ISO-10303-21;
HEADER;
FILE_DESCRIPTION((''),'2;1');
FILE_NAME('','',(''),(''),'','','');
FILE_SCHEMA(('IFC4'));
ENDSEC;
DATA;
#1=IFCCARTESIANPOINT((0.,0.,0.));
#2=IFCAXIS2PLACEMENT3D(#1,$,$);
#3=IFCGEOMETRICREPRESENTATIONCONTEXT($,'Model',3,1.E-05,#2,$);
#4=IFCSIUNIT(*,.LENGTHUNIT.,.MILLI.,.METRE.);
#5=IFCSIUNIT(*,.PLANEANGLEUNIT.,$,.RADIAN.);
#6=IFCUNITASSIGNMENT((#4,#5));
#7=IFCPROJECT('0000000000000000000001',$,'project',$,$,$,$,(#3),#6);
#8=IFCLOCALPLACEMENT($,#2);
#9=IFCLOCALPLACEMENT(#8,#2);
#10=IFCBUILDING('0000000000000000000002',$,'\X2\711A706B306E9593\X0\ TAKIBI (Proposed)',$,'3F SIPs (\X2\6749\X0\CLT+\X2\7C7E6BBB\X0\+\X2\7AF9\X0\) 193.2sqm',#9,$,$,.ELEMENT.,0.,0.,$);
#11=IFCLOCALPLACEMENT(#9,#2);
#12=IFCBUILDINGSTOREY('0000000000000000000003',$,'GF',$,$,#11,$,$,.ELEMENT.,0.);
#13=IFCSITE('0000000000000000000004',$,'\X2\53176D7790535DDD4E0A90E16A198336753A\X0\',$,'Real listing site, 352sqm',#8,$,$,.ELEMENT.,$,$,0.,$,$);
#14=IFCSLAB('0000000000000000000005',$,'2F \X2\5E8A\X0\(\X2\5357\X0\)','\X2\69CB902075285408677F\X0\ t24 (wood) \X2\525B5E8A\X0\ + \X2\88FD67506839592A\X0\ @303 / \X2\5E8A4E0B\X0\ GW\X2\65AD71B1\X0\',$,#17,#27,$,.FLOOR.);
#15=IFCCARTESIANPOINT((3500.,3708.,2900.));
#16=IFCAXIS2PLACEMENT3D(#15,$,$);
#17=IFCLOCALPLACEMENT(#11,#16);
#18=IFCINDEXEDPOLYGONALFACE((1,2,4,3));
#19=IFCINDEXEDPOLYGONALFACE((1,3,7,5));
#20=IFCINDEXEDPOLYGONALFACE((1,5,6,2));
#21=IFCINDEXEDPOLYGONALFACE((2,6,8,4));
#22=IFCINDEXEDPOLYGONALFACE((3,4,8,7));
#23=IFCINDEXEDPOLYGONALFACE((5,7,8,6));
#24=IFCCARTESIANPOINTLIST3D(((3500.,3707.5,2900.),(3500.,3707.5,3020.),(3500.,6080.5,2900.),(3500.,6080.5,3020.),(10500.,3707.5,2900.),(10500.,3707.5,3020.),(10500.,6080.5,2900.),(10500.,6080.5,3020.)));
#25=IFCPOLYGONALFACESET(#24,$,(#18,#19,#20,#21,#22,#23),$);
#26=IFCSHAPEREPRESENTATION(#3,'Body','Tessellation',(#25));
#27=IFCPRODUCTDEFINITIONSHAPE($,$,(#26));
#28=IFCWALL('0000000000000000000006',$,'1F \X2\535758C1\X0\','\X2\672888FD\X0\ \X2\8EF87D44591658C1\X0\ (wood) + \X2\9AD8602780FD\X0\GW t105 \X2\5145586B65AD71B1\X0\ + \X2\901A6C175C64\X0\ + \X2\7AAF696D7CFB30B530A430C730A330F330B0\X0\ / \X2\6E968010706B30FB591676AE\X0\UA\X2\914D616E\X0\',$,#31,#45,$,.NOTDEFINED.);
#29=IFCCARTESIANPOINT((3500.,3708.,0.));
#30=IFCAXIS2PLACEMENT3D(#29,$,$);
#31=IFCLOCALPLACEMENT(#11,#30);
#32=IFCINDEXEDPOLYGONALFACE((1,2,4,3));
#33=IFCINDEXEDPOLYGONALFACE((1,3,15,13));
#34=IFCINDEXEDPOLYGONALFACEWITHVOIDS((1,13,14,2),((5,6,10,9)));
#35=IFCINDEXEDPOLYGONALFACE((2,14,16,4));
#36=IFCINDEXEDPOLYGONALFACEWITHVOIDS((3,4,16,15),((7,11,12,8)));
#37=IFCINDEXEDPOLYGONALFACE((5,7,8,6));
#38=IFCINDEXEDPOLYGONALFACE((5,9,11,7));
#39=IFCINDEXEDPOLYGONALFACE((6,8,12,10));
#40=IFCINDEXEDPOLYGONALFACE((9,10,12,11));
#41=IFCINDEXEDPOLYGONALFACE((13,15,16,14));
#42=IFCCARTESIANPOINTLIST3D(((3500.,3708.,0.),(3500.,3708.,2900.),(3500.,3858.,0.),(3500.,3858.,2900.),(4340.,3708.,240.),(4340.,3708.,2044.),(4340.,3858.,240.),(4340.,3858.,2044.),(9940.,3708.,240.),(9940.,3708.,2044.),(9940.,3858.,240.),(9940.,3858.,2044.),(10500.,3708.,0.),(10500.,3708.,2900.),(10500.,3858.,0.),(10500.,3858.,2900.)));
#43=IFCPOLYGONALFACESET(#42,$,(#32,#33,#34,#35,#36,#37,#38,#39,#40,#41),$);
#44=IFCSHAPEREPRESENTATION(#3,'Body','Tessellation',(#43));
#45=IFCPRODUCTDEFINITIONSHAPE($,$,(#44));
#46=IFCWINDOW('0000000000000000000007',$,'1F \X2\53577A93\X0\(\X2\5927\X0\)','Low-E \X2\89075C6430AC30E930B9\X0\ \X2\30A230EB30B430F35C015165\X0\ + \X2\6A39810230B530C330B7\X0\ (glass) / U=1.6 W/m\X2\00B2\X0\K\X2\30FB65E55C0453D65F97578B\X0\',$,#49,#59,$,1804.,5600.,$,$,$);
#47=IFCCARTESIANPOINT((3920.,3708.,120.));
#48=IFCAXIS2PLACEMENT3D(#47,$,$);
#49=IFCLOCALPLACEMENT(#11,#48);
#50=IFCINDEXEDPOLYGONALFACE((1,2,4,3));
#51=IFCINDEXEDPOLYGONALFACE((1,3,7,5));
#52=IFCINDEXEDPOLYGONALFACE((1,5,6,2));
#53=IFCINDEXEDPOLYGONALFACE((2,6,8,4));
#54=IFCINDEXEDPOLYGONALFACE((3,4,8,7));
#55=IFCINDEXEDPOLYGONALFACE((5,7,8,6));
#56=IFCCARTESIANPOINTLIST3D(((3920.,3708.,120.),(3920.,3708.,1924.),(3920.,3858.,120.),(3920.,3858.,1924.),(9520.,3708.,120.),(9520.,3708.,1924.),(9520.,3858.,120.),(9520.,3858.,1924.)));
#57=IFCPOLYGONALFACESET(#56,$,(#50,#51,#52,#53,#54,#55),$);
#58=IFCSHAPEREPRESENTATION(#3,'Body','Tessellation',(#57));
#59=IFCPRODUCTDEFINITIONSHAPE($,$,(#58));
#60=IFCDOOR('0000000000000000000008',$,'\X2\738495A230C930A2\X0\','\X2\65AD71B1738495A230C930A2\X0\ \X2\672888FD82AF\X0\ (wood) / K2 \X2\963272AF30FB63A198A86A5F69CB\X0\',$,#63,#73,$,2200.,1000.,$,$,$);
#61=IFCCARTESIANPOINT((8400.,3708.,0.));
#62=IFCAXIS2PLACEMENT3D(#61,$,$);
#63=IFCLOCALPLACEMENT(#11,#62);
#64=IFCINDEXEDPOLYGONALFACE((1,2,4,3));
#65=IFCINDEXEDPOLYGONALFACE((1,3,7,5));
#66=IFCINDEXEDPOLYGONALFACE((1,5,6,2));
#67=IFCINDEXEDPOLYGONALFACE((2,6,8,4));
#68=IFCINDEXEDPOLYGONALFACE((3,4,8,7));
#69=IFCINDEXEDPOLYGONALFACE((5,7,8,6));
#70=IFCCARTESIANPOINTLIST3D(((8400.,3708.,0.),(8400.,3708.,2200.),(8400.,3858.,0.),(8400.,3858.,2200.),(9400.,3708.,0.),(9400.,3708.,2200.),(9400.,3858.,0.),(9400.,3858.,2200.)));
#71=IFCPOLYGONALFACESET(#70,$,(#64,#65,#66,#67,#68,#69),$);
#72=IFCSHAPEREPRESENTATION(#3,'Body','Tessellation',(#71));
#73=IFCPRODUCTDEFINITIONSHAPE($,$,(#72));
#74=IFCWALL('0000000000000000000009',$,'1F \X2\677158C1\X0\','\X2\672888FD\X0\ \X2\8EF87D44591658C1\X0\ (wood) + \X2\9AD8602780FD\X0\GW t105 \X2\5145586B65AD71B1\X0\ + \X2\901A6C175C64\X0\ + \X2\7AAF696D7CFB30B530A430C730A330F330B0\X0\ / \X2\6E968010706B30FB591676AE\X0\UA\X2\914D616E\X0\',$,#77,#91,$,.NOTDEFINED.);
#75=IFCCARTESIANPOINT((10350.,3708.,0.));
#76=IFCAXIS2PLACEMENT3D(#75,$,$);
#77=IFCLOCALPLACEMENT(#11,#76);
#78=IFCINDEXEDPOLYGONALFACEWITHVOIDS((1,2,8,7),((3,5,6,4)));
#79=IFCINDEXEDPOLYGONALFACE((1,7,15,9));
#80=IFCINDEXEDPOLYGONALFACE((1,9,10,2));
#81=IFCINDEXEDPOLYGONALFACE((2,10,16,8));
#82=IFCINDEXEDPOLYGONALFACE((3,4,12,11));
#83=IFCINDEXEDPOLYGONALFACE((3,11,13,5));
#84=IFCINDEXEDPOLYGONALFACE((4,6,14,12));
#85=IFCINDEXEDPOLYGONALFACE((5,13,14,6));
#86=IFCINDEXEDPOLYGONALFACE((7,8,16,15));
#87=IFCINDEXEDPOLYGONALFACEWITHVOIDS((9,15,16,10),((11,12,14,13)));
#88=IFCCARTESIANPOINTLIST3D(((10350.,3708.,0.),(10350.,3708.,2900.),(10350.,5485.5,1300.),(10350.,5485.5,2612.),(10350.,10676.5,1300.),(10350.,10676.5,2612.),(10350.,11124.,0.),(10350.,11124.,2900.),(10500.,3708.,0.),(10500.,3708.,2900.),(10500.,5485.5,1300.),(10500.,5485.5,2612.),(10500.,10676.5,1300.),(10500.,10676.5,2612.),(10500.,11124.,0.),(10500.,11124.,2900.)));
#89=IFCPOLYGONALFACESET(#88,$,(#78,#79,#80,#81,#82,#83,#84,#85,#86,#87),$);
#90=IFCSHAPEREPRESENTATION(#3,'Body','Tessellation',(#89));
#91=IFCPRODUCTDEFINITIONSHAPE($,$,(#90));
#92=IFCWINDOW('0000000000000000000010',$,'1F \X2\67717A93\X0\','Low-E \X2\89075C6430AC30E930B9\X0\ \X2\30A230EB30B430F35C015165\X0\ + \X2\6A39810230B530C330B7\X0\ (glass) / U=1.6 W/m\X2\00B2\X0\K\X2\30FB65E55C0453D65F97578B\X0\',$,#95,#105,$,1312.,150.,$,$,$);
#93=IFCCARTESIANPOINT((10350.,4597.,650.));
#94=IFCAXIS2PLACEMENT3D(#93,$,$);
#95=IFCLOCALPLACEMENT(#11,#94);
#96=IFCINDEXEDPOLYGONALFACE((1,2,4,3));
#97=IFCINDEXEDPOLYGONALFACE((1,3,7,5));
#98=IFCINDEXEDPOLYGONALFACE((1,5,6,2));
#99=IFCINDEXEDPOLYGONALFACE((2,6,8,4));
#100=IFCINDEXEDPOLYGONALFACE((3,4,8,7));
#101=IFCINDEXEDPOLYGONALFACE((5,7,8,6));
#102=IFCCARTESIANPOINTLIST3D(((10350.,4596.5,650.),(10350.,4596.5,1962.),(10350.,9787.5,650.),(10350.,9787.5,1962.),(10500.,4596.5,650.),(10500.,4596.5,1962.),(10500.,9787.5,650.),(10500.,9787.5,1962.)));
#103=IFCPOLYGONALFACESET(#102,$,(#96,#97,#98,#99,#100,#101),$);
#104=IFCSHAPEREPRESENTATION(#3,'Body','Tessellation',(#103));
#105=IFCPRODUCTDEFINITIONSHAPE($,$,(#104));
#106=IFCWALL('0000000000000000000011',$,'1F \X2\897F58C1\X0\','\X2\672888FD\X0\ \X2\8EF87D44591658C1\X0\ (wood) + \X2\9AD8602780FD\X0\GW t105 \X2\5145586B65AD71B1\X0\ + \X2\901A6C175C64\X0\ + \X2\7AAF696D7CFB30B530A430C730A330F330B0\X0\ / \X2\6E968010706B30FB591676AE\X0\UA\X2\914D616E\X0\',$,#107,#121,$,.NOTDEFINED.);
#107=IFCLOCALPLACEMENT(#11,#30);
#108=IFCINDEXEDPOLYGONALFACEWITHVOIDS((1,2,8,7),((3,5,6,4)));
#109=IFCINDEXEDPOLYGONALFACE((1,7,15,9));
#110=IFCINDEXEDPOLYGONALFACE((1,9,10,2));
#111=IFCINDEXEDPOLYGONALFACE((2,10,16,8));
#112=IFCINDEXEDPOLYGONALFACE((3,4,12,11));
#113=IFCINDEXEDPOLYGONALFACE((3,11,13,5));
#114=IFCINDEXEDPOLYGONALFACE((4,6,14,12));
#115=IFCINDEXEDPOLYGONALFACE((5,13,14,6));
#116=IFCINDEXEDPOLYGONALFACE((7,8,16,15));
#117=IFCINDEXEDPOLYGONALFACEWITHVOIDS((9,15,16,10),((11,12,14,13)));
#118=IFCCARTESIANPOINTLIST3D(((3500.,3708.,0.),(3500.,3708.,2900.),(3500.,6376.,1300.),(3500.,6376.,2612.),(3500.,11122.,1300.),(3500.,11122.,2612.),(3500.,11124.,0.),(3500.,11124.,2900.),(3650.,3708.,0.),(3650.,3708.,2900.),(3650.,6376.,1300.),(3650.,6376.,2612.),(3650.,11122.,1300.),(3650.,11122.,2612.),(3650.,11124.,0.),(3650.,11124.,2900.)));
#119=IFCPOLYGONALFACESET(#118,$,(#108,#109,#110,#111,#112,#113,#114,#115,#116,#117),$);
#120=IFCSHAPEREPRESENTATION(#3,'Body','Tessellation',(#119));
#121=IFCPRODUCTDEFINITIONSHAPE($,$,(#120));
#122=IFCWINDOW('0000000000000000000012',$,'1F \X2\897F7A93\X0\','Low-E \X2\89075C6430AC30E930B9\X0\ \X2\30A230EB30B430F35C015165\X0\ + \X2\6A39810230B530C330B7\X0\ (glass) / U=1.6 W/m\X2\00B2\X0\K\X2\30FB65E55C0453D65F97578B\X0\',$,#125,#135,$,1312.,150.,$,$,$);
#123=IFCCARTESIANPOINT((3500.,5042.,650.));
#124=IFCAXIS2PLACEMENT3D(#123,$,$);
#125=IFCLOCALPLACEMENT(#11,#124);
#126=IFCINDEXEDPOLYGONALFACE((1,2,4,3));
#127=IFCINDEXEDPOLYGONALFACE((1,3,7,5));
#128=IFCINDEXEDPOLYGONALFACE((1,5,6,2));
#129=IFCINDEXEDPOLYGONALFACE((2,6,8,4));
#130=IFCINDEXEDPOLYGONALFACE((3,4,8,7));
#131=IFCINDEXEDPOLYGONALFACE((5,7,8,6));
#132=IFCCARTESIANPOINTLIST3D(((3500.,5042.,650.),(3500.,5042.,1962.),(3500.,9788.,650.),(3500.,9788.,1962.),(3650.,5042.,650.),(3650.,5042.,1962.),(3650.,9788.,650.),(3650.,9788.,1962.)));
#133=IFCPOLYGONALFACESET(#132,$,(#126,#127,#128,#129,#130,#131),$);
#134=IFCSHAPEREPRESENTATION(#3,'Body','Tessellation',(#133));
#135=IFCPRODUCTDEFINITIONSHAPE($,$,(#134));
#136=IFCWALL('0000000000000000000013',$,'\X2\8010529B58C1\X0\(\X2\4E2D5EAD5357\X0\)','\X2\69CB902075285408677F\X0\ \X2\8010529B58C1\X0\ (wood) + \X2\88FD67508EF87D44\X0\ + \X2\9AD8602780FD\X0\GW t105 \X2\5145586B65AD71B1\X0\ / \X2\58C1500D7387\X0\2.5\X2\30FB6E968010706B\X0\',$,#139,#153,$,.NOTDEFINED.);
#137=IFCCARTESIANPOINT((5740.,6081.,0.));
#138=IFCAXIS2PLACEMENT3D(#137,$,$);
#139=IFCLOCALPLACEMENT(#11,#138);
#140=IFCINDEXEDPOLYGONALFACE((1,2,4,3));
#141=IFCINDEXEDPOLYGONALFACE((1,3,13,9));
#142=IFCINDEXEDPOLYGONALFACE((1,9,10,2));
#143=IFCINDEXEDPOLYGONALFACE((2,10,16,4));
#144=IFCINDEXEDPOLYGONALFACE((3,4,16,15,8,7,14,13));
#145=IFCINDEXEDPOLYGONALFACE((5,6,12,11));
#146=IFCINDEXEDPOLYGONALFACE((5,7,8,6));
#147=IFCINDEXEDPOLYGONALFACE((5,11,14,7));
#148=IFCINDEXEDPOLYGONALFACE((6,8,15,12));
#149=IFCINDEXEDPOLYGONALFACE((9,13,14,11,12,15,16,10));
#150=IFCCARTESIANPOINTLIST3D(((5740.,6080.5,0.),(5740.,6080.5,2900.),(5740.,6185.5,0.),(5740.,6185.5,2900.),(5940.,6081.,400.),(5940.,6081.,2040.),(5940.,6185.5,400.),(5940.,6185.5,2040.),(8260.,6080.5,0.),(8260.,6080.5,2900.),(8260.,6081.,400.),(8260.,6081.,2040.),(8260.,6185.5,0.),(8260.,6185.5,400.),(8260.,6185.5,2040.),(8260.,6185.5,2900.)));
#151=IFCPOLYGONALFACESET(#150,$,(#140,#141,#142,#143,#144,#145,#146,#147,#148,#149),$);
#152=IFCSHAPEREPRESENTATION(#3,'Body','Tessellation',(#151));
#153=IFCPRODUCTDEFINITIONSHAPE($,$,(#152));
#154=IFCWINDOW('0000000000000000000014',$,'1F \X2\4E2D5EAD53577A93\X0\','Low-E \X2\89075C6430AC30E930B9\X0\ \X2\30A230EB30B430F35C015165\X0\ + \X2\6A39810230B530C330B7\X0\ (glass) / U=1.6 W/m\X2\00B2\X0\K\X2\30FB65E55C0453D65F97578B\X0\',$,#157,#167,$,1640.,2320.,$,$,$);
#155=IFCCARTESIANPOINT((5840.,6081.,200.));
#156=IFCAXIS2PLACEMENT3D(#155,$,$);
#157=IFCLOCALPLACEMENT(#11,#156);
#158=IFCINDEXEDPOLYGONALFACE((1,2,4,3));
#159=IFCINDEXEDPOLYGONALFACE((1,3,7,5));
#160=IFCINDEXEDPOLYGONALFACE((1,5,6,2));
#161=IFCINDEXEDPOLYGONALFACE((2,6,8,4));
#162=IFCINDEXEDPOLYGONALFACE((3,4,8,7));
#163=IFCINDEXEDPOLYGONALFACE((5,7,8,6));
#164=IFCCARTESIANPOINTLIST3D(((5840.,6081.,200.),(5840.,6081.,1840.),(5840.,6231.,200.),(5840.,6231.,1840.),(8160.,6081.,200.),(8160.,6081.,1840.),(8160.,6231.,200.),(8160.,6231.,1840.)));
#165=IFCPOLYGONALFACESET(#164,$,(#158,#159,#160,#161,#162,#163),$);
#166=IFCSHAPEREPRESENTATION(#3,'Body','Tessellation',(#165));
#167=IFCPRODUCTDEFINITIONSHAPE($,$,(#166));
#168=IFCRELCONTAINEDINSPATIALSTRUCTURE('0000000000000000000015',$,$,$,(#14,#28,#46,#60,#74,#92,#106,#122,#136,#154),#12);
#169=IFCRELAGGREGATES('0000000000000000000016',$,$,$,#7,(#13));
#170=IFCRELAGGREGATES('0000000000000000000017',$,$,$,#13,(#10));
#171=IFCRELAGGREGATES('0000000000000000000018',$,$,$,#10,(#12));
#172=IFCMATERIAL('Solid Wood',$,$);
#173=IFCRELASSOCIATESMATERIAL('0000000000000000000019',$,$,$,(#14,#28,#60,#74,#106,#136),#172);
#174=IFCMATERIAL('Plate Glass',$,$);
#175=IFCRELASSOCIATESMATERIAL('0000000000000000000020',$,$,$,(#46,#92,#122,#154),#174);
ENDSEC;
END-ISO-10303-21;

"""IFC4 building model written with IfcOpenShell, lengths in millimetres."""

from ifc_helpers import new_model, si_unit, frame, frame_2d, origin, place, context, project, spatial, rectangle, extrude, material, element, fill, save


model = new_model("IFC4")

# Units and contexts
model_context = context("Model", 3, precision=1e-05, world=origin())
ifc_project = project(units=[si_unit("LENGTHUNIT", "METRE", prefix="MILLI"), si_unit("PLANEANGLEUNIT", "RADIAN")], contexts=[model_context])

# Site, building, storey
site_placement = place(None, origin())
site = spatial("IfcSite", under=ifc_project, at=site_placement, Name="北海道川上郡標茶町", ObjectType="Real listing site, 352sqm", CompositionType="ELEMENT", RefElevation=0.0)
building_placement = place(site_placement, origin())
building = spatial("IfcBuilding", under=site, at=building_placement, Name="焚火の間 TAKIBI (Proposed)", ObjectType="3F SIPs (杉CLT+籾殻+竹) 193.2sqm", CompositionType="ELEMENT", ElevationOfRefHeight=0.0, ElevationOfTerrain=0.0)
storey_placement = place(building_placement, origin())
storey = spatial("IfcBuildingStorey", under=building, at=storey_placement, Name="GF", CompositionType="ELEMENT", Elevation=0.0)

# Slab
ifc_material_1 = material(Name="Solid Wood")
slab_1_placement = place(storey_placement, frame((3500.0, 3708.0, 2900.0)))
element("IfcSlab", 1, at=slab_1_placement, inside=storey, material=ifc_material_1, Name="2F 床(南)", Description="構造用合板 t24 (wood) 剛床 + 製材根太 @303 / 床下 GW断熱", PredefinedType="FLOOR", context=model_context, shape_type="SweptSolid", body=[
    extrude(rectangle(XDim=7000.0, YDim=2373.0, at=frame_2d((3500.0, 1186.0))), frame((3500.0, 3708.0, 2900.0)), (0.0, 0.0, 1.0), 120.0),
])

# Wall, openings, window, door
wall_1_placement = place(storey_placement, frame((3500.0, 3708.0, 0.0)))
wall_1 = element("IfcWall", 2, at=wall_1_placement, inside=storey, material=ifc_material_1, Name="1F 南壁", Description="木製 軸組外壁 (wood) + 高性能GW t105 充填断熱 + 通気層 + 窯業系サイディング / 準耐火・外皮UA配慮", PredefinedType="NOTDEFINED", context=model_context, shape_type="SweptSolid", body=[
    extrude(rectangle(XDim=7000.0, YDim=150.0, at=frame_2d((3500.0, 75.0))), frame((3500.0, 3708.0, 0.0)), (0.0, 0.0, 1.0), 2900.0),
])
opening_1_placement = place(storey_placement, frame((3920.0, 3708.0, 120.0)))
opening_1 = element("IfcOpeningElement", 3, at=opening_1_placement, cuts=wall_1, PredefinedType="NOTDEFINED", context=model_context, shape_type="SweptSolid", body=[
    extrude(rectangle(XDim=5600.0, YDim=150.0, at=frame_2d((2800.0, 75.0))), frame((3920.0, 3708.0, 120.0)), (0.0, 0.0, 1.0), 1804.0),
])
opening_2_placement = place(storey_placement, frame((8400.0, 3708.0, 0.0)))
opening_2 = element("IfcOpeningElement", 4, at=opening_2_placement, cuts=wall_1, PredefinedType="NOTDEFINED", context=model_context, shape_type="SweptSolid", body=[
    extrude(rectangle(XDim=1000.0, YDim=150.0, at=frame_2d((500.0, 75.0))), frame((8400.0, 3708.0, 0.0)), (0.0, 0.0, 1.0), 2200.0),
])
ifc_material_2 = material(Name="Plate Glass")
window_1_placement = place(storey_placement, frame((3920.0, 3708.0, 120.0)))
window_1 = element("IfcWindow", 5, at=window_1_placement, inside=storey, material=ifc_material_2, Name="1F 南窓(大)", Description="Low-E 複層ガラス アルゴン封入 + 樹脂サッシ (glass) / U=1.6 W/m²K・日射取得型", OverallHeight=1804.0, OverallWidth=5600.0, context=model_context, shape_type="SweptSolid", body=[
    extrude(rectangle(XDim=5600.0, YDim=150.0, at=frame_2d((2800.0, 75.0))), frame((3920.0, 3708.0, 120.0)), (0.0, 0.0, 1.0), 1804.0),
])
fill(opening_1, window_1)
door_placement = place(storey_placement, frame((8400.0, 3708.0, 0.0)))
door = element("IfcDoor", 6, at=door_placement, inside=storey, material=ifc_material_1, Name="玄関ドア", Description="断熱玄関ドア 木製芯 (wood) / K2 防犯・採風機構", OverallHeight=2200.0, OverallWidth=1000.0, context=model_context, shape_type="SweptSolid", body=[
    extrude(rectangle(XDim=1000.0, YDim=150.0, at=frame_2d((500.0, 75.0))), frame((8400.0, 3708.0, 0.0)), (0.0, 0.0, 1.0), 2200.0),
])
fill(opening_2, door)

# Walls, openings, windows
wall_2_placement = place(storey_placement, frame((10350.0, 3708.0, 0.0)))
wall_2 = element("IfcWall", 7, at=wall_2_placement, inside=storey, material=ifc_material_1, Name="1F 東壁", Description="木製 軸組外壁 (wood) + 高性能GW t105 充填断熱 + 通気層 + 窯業系サイディング / 準耐火・外皮UA配慮", PredefinedType="NOTDEFINED", context=model_context, shape_type="SweptSolid", body=[
    extrude(rectangle(XDim=150.0, YDim=7416.0, at=frame_2d((75.0, 3708.0))), frame((10350.0, 3708.0, 0.0)), (0.0, 0.0, 1.0), 2900.0),
])
opening_3_placement = place(storey_placement, frame((10350.0, 4597.0, 650.0)))
opening_3 = element("IfcOpeningElement", 8, at=opening_3_placement, cuts=wall_2, PredefinedType="NOTDEFINED", context=model_context, shape_type="SweptSolid", body=[
    extrude(rectangle(XDim=150.0, YDim=5191.0, at=frame_2d((75.0, 2595.0))), frame((10350.0, 4597.0, 650.0)), (0.0, 0.0, 1.0), 1312.0),
])
window_2_placement = place(storey_placement, frame((10350.0, 4597.0, 650.0)))
window_2 = element("IfcWindow", 9, at=window_2_placement, inside=storey, material=ifc_material_2, Name="1F 東窓", Description="Low-E 複層ガラス アルゴン封入 + 樹脂サッシ (glass) / U=1.6 W/m²K・日射取得型", OverallHeight=1312.0, OverallWidth=150.0, context=model_context, shape_type="SweptSolid", body=[
    extrude(rectangle(XDim=150.0, YDim=5191.0, at=frame_2d((75.0, 2595.0))), frame((10350.0, 4597.0, 650.0)), (0.0, 0.0, 1.0), 1312.0),
])
fill(opening_3, window_2)
wall_3_placement = place(storey_placement, frame((3500.0, 3708.0, 0.0)))
wall_3 = element("IfcWall", 10, at=wall_3_placement, inside=storey, material=ifc_material_1, Name="1F 西壁", Description="木製 軸組外壁 (wood) + 高性能GW t105 充填断熱 + 通気層 + 窯業系サイディング / 準耐火・外皮UA配慮", PredefinedType="NOTDEFINED", context=model_context, shape_type="SweptSolid", body=[
    extrude(rectangle(XDim=150.0, YDim=7416.0, at=frame_2d((75.0, 3708.0))), frame((3500.0, 3708.0, 0.0)), (0.0, 0.0, 1.0), 2900.0),
])
opening_4_placement = place(storey_placement, frame((3500.0, 5042.0, 650.0)))
opening_4 = element("IfcOpeningElement", 11, at=opening_4_placement, cuts=wall_3, PredefinedType="NOTDEFINED", context=model_context, shape_type="SweptSolid", body=[
    extrude(rectangle(XDim=150.0, YDim=4746.0, at=frame_2d((75.0, 2373.0))), frame((3500.0, 5042.0, 650.0)), (0.0, 0.0, 1.0), 1312.0),
])
window_3_placement = place(storey_placement, frame((3500.0, 5042.0, 650.0)))
window_3 = element("IfcWindow", 12, at=window_3_placement, inside=storey, material=ifc_material_2, Name="1F 西窓", Description="Low-E 複層ガラス アルゴン封入 + 樹脂サッシ (glass) / U=1.6 W/m²K・日射取得型", OverallHeight=1312.0, OverallWidth=150.0, context=model_context, shape_type="SweptSolid", body=[
    extrude(rectangle(XDim=150.0, YDim=4746.0, at=frame_2d((75.0, 2373.0))), frame((3500.0, 5042.0, 650.0)), (0.0, 0.0, 1.0), 1312.0),
])
fill(opening_4, window_3)
wall_4_placement = place(storey_placement, frame((5740.0, 6081.0, 0.0)))
wall_4 = element("IfcWall", 13, at=wall_4_placement, inside=storey, material=ifc_material_1, Name="耐力壁(中庭南)", Description="構造用合板 耐力壁 (wood) + 製材軸組 + 高性能GW t105 充填断熱 / 壁倍率2.5・準耐火", PredefinedType="NOTDEFINED", context=model_context, shape_type="SweptSolid", body=[
    extrude(rectangle(XDim=2520.0, YDim=105.0, at=frame_2d((1260.0, 52.0))), frame((5740.0, 6081.0, 0.0)), (0.0, 0.0, 1.0), 2900.0),
])
opening_5_placement = place(storey_placement, frame((5840.0, 6081.0, 200.0)))
opening_5 = element("IfcOpeningElement", 14, at=opening_5_placement, cuts=wall_4, PredefinedType="NOTDEFINED", context=model_context, shape_type="SweptSolid", body=[
    extrude(rectangle(XDim=2320.0, YDim=150.0, at=frame_2d((1160.0, 75.0))), frame((5840.0, 6081.0, 200.0)), (0.0, 0.0, 1.0), 1640.0),
])
window_4_placement = place(storey_placement, frame((5840.0, 6081.0, 200.0)))
window_4 = element("IfcWindow", 15, at=window_4_placement, inside=storey, material=ifc_material_2, Name="1F 中庭南窓", Description="Low-E 複層ガラス アルゴン封入 + 樹脂サッシ (glass) / U=1.6 W/m²K・日射取得型", OverallHeight=1640.0, OverallWidth=2320.0, context=model_context, shape_type="SweptSolid", body=[
    extrude(rectangle(XDim=2320.0, YDim=150.0, at=frame_2d((1160.0, 75.0))), frame((5840.0, 6081.0, 200.0)), (0.0, 0.0, 1.0), 1640.0),
])
fill(opening_5, window_4)

save(model, "model.ifc")
